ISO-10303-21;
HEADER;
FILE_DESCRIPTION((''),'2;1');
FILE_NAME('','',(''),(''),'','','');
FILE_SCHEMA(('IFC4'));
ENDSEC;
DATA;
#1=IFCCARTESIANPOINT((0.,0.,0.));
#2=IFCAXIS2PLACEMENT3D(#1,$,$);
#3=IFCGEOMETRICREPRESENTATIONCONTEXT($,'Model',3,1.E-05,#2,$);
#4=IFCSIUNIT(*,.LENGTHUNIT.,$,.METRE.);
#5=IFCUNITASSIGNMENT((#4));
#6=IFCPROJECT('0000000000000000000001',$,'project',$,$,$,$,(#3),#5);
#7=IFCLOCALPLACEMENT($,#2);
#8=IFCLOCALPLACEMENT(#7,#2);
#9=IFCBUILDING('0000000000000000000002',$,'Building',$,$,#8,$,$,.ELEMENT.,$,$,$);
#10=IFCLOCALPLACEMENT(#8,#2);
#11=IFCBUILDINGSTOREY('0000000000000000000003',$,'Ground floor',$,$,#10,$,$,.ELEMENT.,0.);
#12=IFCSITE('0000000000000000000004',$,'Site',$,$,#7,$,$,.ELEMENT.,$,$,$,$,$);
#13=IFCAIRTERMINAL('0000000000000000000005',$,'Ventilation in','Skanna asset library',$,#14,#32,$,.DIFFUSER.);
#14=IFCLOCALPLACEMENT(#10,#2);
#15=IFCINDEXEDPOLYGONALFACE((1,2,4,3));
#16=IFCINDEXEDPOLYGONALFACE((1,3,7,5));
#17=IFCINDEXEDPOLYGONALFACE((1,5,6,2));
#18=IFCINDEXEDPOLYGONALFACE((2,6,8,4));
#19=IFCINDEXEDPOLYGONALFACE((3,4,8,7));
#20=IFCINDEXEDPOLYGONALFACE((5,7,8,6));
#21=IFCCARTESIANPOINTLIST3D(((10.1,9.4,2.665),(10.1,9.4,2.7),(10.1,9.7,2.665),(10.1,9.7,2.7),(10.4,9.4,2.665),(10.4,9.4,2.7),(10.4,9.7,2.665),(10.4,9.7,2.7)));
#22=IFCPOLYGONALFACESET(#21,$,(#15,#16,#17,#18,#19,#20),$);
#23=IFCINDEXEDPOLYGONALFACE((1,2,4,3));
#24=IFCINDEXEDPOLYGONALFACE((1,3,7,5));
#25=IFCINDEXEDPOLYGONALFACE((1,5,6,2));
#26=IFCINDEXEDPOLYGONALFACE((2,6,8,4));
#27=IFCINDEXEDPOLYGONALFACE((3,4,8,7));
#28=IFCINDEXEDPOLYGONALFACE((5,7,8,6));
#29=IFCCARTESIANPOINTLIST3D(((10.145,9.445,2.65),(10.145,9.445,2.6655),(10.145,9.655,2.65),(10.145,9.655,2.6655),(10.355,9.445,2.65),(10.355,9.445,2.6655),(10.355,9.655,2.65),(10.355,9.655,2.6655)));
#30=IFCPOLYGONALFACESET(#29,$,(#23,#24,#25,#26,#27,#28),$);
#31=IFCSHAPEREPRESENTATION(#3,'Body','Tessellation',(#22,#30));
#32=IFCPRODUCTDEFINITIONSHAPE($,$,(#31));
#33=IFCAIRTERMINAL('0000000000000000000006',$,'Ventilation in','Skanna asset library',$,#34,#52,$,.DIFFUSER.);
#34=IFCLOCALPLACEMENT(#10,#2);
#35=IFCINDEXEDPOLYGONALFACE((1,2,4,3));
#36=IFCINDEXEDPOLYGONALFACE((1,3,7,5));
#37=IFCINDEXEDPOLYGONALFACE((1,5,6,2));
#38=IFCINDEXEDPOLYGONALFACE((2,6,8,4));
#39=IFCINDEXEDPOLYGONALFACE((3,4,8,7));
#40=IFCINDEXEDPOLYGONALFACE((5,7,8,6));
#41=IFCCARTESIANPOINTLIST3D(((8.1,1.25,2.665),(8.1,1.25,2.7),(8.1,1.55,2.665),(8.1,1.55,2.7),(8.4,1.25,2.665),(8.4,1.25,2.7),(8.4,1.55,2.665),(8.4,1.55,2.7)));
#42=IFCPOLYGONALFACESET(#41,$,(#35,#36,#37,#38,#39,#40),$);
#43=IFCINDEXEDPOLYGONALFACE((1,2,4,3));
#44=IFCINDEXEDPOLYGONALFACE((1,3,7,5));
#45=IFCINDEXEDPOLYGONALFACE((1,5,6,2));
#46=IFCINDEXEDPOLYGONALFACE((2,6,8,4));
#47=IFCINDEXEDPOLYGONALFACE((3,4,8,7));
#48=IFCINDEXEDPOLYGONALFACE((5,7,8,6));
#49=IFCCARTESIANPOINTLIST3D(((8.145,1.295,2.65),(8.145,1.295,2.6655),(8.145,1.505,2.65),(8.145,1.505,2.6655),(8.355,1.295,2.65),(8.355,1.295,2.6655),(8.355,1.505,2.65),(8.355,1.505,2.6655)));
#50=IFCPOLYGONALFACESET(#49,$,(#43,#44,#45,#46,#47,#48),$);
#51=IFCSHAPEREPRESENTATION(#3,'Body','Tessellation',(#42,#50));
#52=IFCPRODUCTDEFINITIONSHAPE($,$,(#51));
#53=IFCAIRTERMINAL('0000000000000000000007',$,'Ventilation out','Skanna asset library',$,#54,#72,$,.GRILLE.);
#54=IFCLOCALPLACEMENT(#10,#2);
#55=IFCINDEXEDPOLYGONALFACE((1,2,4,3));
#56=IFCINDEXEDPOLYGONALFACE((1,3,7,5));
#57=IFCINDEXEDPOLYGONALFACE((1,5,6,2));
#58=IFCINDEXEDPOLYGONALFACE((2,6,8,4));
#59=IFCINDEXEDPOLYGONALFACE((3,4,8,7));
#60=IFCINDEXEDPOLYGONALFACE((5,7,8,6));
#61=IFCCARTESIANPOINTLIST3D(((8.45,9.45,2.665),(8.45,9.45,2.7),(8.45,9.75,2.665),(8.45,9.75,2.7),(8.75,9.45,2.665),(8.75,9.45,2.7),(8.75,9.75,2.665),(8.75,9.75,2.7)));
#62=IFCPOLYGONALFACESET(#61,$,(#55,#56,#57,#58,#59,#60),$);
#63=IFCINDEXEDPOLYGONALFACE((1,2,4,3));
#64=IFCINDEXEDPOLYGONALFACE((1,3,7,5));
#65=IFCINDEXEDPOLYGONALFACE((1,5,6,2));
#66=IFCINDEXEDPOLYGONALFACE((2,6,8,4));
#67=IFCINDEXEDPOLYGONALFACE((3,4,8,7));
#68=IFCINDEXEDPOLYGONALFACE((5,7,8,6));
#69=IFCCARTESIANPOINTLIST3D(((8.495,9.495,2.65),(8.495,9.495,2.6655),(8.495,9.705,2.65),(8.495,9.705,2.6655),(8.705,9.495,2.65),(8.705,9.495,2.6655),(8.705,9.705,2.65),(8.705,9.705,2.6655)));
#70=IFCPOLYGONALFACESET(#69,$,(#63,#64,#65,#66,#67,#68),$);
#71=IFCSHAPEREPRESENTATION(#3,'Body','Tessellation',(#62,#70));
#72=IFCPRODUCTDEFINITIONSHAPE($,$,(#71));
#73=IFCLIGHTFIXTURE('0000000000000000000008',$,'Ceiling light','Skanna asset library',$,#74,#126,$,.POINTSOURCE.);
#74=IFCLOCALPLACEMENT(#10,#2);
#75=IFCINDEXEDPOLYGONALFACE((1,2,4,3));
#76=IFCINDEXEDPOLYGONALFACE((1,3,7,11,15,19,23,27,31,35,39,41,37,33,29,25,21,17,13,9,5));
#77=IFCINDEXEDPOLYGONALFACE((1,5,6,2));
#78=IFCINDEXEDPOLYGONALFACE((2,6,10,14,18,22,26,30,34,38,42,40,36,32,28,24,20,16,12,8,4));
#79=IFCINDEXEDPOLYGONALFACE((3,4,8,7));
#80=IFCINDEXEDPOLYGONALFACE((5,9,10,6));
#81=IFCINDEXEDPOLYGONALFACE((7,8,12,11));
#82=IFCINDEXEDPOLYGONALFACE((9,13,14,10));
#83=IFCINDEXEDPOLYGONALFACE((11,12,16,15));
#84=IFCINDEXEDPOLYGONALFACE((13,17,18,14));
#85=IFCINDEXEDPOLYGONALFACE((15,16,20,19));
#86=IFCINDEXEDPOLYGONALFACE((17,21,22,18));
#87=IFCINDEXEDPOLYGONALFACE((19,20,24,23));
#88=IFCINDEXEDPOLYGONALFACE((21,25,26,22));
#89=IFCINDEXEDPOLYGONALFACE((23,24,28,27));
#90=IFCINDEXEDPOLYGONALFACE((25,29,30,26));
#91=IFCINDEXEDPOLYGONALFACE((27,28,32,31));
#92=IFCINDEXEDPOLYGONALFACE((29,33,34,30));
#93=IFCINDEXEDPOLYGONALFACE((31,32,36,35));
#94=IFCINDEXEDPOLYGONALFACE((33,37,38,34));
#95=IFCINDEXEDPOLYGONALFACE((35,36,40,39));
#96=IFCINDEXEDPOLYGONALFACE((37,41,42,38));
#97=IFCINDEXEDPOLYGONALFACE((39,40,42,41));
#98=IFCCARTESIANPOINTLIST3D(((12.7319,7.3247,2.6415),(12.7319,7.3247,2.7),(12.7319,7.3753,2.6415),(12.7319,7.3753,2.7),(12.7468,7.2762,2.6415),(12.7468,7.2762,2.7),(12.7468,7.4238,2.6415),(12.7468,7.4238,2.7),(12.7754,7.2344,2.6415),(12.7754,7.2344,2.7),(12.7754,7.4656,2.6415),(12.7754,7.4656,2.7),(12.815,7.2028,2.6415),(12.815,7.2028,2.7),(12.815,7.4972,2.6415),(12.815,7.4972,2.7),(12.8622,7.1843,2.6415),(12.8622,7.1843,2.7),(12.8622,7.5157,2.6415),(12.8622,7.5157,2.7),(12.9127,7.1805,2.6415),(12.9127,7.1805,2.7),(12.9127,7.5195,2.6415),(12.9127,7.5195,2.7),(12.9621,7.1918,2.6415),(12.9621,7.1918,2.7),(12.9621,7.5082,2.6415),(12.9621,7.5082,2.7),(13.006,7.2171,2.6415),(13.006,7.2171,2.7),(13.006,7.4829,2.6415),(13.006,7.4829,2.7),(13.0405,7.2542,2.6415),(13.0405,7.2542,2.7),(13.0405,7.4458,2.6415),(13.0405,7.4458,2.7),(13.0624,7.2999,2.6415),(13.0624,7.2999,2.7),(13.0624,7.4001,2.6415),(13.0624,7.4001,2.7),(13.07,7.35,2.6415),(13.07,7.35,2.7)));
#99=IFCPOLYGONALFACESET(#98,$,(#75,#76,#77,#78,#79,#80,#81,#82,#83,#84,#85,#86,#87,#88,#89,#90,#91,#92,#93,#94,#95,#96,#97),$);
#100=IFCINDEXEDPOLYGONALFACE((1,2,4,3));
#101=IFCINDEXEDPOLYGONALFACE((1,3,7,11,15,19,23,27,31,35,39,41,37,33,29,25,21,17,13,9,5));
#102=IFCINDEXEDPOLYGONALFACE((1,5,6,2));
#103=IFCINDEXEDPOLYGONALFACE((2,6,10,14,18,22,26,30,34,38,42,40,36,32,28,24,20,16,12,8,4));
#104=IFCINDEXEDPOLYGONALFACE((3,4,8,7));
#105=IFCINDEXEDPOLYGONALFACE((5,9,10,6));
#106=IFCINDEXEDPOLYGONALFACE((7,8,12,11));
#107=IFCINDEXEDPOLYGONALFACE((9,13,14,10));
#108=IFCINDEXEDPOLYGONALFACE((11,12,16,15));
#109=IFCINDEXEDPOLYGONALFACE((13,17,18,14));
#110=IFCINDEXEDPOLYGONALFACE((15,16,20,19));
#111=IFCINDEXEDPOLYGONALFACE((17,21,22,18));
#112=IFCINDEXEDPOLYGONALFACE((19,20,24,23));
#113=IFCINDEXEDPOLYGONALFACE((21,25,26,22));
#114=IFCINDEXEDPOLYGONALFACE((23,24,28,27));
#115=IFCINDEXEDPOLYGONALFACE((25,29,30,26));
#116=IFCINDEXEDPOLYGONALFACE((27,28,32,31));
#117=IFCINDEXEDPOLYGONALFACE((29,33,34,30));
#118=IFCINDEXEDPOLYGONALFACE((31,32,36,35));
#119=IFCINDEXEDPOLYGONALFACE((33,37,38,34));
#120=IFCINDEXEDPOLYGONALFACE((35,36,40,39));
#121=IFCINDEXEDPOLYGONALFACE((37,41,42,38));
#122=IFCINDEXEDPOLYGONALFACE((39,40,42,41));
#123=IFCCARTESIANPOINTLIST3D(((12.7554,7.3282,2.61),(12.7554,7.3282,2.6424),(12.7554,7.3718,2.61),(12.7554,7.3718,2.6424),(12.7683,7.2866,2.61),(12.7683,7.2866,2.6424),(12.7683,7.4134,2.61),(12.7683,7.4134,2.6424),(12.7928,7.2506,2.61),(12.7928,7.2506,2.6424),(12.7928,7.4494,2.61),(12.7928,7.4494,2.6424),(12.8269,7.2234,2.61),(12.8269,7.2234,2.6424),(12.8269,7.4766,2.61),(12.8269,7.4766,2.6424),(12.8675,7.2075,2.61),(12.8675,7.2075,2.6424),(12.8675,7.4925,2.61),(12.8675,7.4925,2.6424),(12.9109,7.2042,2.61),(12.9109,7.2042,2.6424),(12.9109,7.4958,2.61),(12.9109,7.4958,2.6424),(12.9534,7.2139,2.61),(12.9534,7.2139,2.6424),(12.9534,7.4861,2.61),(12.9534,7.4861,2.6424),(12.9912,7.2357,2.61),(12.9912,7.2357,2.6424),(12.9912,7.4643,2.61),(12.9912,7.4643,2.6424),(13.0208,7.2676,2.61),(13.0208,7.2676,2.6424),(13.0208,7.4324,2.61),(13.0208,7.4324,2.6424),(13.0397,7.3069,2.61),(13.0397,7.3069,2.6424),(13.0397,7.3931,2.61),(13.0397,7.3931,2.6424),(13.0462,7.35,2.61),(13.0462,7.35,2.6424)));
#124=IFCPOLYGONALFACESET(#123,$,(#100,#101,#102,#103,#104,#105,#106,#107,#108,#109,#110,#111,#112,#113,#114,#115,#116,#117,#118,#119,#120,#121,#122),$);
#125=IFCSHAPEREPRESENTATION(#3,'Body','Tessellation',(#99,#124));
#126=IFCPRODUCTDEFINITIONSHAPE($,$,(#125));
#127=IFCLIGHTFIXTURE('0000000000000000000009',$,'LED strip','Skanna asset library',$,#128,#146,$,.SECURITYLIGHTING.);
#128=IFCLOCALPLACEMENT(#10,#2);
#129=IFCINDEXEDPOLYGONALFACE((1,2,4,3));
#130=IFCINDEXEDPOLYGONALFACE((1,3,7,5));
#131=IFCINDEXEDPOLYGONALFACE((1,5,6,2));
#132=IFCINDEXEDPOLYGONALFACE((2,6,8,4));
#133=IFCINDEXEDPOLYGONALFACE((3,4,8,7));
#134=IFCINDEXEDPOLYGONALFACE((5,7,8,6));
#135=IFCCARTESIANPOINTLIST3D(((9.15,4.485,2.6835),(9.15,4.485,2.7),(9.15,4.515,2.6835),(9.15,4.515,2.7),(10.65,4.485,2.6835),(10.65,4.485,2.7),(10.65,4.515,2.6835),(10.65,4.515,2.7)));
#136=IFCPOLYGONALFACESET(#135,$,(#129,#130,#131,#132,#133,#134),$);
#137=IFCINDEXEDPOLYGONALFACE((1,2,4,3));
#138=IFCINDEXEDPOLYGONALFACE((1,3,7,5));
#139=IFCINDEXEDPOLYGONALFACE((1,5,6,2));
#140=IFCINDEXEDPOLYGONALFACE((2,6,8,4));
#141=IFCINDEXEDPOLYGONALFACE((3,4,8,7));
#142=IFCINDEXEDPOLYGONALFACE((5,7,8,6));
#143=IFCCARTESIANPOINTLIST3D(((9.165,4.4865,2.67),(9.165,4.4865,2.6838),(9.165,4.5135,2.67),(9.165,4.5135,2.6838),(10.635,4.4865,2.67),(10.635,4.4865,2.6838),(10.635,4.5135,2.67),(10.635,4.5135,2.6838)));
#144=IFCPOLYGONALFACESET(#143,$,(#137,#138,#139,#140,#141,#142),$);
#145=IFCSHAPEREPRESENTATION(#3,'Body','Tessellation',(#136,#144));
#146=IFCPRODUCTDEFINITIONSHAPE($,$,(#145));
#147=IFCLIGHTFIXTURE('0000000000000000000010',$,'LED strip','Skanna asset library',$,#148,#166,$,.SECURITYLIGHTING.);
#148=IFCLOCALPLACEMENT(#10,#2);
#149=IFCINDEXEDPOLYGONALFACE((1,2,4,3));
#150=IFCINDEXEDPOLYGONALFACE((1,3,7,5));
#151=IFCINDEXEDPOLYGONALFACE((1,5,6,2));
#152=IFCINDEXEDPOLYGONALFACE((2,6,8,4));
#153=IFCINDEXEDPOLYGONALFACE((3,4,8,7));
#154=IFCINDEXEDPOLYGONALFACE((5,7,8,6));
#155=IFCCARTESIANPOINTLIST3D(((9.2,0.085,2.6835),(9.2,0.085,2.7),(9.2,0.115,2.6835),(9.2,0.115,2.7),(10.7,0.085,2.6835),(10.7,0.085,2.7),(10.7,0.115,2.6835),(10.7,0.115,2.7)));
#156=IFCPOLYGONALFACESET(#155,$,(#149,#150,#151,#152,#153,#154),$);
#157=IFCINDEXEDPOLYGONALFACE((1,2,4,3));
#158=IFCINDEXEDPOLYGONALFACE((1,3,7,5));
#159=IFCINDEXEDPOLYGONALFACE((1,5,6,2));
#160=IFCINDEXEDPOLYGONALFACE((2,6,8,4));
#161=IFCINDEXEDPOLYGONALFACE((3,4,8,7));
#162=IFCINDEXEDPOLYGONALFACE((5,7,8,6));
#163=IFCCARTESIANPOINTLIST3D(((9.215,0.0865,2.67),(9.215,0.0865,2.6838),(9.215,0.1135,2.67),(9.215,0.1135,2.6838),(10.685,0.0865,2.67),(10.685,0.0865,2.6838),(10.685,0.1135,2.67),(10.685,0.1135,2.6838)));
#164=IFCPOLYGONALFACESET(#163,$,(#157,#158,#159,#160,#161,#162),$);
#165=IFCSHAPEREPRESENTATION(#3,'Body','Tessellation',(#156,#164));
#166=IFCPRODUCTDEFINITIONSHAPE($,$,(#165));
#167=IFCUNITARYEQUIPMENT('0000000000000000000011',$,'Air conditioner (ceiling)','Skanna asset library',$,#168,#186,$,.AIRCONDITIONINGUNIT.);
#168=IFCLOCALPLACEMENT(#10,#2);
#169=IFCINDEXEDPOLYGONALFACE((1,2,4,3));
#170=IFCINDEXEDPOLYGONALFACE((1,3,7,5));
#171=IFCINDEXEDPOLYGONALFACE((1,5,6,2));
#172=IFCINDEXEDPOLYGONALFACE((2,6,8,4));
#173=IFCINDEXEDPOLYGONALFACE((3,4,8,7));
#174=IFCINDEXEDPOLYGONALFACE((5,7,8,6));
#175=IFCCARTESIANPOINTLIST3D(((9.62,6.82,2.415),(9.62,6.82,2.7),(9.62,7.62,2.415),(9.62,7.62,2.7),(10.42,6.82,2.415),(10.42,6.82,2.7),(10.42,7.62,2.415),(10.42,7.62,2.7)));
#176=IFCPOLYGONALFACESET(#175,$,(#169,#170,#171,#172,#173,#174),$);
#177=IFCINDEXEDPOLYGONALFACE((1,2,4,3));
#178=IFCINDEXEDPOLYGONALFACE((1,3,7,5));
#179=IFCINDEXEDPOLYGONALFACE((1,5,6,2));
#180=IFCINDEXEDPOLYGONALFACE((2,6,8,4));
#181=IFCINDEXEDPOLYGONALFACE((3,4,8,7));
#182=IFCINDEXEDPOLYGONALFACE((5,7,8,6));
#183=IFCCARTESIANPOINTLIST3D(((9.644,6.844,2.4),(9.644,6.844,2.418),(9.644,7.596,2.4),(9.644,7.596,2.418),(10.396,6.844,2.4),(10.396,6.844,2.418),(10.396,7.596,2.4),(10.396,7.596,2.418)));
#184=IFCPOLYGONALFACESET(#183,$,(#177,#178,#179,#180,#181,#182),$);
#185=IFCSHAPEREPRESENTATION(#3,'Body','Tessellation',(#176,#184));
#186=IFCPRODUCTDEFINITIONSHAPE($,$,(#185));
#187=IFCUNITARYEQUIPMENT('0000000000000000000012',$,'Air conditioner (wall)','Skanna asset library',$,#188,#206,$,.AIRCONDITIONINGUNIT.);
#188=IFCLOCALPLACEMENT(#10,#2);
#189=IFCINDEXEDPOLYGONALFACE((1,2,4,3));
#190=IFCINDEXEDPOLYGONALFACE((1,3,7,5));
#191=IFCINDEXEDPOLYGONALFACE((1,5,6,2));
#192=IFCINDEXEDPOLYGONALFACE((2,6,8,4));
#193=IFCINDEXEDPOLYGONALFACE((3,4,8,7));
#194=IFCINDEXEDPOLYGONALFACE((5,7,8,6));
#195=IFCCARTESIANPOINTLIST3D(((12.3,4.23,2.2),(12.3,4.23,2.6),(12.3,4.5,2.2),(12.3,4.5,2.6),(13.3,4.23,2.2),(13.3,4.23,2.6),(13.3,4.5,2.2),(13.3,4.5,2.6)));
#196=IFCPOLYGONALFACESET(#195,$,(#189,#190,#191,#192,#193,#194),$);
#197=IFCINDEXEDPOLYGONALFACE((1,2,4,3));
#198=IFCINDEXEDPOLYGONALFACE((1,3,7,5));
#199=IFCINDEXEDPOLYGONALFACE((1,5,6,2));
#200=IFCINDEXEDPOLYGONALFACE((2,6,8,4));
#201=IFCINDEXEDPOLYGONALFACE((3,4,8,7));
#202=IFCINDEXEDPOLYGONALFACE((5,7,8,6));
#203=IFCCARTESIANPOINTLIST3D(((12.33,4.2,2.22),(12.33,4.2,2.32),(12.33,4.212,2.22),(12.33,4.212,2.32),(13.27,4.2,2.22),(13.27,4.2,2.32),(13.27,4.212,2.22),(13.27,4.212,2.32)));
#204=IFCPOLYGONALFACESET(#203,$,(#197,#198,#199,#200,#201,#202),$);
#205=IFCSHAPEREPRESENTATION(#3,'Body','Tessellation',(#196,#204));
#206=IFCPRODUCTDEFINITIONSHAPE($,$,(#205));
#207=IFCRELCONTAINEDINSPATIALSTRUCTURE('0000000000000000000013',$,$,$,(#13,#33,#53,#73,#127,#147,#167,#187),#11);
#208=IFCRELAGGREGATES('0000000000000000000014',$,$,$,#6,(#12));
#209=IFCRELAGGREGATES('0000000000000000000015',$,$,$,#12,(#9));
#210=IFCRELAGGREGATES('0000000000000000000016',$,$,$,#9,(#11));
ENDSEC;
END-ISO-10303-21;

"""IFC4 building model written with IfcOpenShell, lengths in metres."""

from ifc_helpers import new_model, si_unit, frame, frame_2d, origin, origin_2d, place, context, project, spatial, rectangle, circle, extrude, element, save


model = new_model("IFC4")

# Units and contexts
model_context = context("Model", 3, precision=1e-05, world=origin())
ifc_project = project(units=[si_unit("LENGTHUNIT", "METRE")], contexts=[model_context])

# Site, building, storey
site_placement = place(None, origin())
site = spatial("IfcSite", under=ifc_project, at=site_placement, Name="Site", CompositionType="ELEMENT")
building_placement = place(site_placement, origin())
building = spatial("IfcBuilding", under=site, at=building_placement, Name="Building", CompositionType="ELEMENT")
storey_placement = place(building_placement, origin())
storey = spatial("IfcBuildingStorey", under=building, at=storey_placement, Name="Ground floor", CompositionType="ELEMENT", Elevation=0.0)

# Air terminals
for number, where, z_axis, x_axis, name in (
    (1, (10.25, 9.55, 2.65), (0.0, 0.0, 1.0), (1.0, 0.0, 0.0), "Ventilation in"),
    (2, (8.25, 1.4, 2.65), (0.0, 0.0, 1.0), (1.0, 0.0, 0.0), "Ventilation in"),
):
    element("IfcAirTerminal", number, at=place(storey_placement, frame(where, z_axis=z_axis, x_axis=x_axis)), inside=storey, Name=name, Description="Skanna asset library", PredefinedType="DIFFUSER", context=model_context, shape_type="SweptSolid", body=[
        extrude(rectangle(XDim=0.3, YDim=0.3, at=origin_2d()), frame((0.0, 0.0, 0.015)), (0.0, 0.0, 1.0), 0.035),
        extrude(rectangle(XDim=0.21, YDim=0.21, at=origin_2d()), origin(), (0.0, 0.0, 1.0), 0.0155),
    ])
air_terminal_placement = place(storey_placement, frame((8.6, 9.6, 2.65), z_axis=(0.0, 0.0, 1.0), x_axis=(1.0, 0.0, 0.0)))
element("IfcAirTerminal", 3, at=air_terminal_placement, inside=storey, Name="Ventilation out", Description="Skanna asset library", PredefinedType="GRILLE", context=model_context, shape_type="SweptSolid", body=[
    extrude(rectangle(XDim=0.3, YDim=0.3, at=origin_2d()), frame((0.0, 0.0, 0.015)), (0.0, 0.0, 1.0), 0.035),
    extrude(rectangle(XDim=0.21, YDim=0.21, at=origin_2d()), origin(), (0.0, 0.0, 1.0), 0.0155),
])

# Light fixtures
light_fixture_1_placement = place(storey_placement, frame((12.9, 7.35, 2.61), z_axis=(0.0, 0.0, 1.0), x_axis=(1.0, 0.0, 0.0)))
element("IfcLightFixture", 4, at=light_fixture_1_placement, inside=storey, Name="Ceiling light", Description="Skanna asset library", PredefinedType="POINTSOURCE", context=model_context, shape_type="SweptSolid", body=[
    extrude(circle(Radius=0.17, at=origin_2d()), frame((0.0, 0.0, 0.0315)), (0.0, 0.0, 1.0), 0.0585),
    extrude(circle(Radius=0.1462, at=origin_2d()), origin(), (0.0, 0.0, 1.0), 0.0324),
])
for number, where, z_axis, x_axis, name in (
    (5, (9.9, 4.5, 2.67), (0.0, 0.0, 1.0), (1.0, 0.0, 0.0), "LED strip"),
    (6, (9.95, 0.1, 2.67), (0.0, 0.0, 1.0), (1.0, 0.0, 0.0), "LED strip"),
):
    element("IfcLightFixture", number, at=place(storey_placement, frame(where, z_axis=z_axis, x_axis=x_axis)), inside=storey, Name=name, Description="Skanna asset library", PredefinedType="SECURITYLIGHTING", context=model_context, shape_type="SweptSolid", body=[
        extrude(rectangle(XDim=1.5, YDim=0.03, at=origin_2d()), frame((0.0, 0.0, 0.0135)), (0.0, 0.0, 1.0), 0.0165),
        extrude(rectangle(XDim=1.47, YDim=0.027, at=origin_2d()), origin(), (0.0, 0.0, 1.0), 0.0138),
    ])

# Unitary equipment
unitary_equipment_1_placement = place(storey_placement, frame((10.02, 7.22, 2.4), z_axis=(0.0, 0.0, 1.0), x_axis=(1.0, 0.0, 0.0)))
element("IfcUnitaryEquipment", 7, at=unitary_equipment_1_placement, inside=storey, Name="Air conditioner (ceiling)", Description="Skanna asset library", PredefinedType="AIRCONDITIONINGUNIT", context=model_context, shape_type="SweptSolid", body=[
    extrude(rectangle(XDim=0.8, YDim=0.8, at=origin_2d()), frame((0.0, 0.0, 0.015)), (0.0, 0.0, 1.0), 0.285),
    extrude(rectangle(XDim=0.752, YDim=0.752, at=origin_2d()), origin(), (0.0, 0.0, 1.0), 0.018),
])
unitary_equipment_2_placement = place(storey_placement, frame((12.8, 4.35, 2.2), z_axis=(0.0, 0.0, 1.0), x_axis=(1.0, 0.0, 0.0)))
element("IfcUnitaryEquipment", 8, at=unitary_equipment_2_placement, inside=storey, Name="Air conditioner (wall)", Description="Skanna asset library", PredefinedType="AIRCONDITIONINGUNIT", context=model_context, shape_type="SweptSolid", body=[
    extrude(rectangle(XDim=1.0, YDim=0.27, at=frame_2d((0.0, 0.015))), origin(), (0.0, 0.0, 1.0), 0.4),
    extrude(rectangle(XDim=0.94, YDim=0.012, at=frame_2d((0.0, -0.144))), frame((0.0, 0.0, 0.02)), (0.0, 0.0, 1.0), 0.1),
])

save(model, "model.ifc")
